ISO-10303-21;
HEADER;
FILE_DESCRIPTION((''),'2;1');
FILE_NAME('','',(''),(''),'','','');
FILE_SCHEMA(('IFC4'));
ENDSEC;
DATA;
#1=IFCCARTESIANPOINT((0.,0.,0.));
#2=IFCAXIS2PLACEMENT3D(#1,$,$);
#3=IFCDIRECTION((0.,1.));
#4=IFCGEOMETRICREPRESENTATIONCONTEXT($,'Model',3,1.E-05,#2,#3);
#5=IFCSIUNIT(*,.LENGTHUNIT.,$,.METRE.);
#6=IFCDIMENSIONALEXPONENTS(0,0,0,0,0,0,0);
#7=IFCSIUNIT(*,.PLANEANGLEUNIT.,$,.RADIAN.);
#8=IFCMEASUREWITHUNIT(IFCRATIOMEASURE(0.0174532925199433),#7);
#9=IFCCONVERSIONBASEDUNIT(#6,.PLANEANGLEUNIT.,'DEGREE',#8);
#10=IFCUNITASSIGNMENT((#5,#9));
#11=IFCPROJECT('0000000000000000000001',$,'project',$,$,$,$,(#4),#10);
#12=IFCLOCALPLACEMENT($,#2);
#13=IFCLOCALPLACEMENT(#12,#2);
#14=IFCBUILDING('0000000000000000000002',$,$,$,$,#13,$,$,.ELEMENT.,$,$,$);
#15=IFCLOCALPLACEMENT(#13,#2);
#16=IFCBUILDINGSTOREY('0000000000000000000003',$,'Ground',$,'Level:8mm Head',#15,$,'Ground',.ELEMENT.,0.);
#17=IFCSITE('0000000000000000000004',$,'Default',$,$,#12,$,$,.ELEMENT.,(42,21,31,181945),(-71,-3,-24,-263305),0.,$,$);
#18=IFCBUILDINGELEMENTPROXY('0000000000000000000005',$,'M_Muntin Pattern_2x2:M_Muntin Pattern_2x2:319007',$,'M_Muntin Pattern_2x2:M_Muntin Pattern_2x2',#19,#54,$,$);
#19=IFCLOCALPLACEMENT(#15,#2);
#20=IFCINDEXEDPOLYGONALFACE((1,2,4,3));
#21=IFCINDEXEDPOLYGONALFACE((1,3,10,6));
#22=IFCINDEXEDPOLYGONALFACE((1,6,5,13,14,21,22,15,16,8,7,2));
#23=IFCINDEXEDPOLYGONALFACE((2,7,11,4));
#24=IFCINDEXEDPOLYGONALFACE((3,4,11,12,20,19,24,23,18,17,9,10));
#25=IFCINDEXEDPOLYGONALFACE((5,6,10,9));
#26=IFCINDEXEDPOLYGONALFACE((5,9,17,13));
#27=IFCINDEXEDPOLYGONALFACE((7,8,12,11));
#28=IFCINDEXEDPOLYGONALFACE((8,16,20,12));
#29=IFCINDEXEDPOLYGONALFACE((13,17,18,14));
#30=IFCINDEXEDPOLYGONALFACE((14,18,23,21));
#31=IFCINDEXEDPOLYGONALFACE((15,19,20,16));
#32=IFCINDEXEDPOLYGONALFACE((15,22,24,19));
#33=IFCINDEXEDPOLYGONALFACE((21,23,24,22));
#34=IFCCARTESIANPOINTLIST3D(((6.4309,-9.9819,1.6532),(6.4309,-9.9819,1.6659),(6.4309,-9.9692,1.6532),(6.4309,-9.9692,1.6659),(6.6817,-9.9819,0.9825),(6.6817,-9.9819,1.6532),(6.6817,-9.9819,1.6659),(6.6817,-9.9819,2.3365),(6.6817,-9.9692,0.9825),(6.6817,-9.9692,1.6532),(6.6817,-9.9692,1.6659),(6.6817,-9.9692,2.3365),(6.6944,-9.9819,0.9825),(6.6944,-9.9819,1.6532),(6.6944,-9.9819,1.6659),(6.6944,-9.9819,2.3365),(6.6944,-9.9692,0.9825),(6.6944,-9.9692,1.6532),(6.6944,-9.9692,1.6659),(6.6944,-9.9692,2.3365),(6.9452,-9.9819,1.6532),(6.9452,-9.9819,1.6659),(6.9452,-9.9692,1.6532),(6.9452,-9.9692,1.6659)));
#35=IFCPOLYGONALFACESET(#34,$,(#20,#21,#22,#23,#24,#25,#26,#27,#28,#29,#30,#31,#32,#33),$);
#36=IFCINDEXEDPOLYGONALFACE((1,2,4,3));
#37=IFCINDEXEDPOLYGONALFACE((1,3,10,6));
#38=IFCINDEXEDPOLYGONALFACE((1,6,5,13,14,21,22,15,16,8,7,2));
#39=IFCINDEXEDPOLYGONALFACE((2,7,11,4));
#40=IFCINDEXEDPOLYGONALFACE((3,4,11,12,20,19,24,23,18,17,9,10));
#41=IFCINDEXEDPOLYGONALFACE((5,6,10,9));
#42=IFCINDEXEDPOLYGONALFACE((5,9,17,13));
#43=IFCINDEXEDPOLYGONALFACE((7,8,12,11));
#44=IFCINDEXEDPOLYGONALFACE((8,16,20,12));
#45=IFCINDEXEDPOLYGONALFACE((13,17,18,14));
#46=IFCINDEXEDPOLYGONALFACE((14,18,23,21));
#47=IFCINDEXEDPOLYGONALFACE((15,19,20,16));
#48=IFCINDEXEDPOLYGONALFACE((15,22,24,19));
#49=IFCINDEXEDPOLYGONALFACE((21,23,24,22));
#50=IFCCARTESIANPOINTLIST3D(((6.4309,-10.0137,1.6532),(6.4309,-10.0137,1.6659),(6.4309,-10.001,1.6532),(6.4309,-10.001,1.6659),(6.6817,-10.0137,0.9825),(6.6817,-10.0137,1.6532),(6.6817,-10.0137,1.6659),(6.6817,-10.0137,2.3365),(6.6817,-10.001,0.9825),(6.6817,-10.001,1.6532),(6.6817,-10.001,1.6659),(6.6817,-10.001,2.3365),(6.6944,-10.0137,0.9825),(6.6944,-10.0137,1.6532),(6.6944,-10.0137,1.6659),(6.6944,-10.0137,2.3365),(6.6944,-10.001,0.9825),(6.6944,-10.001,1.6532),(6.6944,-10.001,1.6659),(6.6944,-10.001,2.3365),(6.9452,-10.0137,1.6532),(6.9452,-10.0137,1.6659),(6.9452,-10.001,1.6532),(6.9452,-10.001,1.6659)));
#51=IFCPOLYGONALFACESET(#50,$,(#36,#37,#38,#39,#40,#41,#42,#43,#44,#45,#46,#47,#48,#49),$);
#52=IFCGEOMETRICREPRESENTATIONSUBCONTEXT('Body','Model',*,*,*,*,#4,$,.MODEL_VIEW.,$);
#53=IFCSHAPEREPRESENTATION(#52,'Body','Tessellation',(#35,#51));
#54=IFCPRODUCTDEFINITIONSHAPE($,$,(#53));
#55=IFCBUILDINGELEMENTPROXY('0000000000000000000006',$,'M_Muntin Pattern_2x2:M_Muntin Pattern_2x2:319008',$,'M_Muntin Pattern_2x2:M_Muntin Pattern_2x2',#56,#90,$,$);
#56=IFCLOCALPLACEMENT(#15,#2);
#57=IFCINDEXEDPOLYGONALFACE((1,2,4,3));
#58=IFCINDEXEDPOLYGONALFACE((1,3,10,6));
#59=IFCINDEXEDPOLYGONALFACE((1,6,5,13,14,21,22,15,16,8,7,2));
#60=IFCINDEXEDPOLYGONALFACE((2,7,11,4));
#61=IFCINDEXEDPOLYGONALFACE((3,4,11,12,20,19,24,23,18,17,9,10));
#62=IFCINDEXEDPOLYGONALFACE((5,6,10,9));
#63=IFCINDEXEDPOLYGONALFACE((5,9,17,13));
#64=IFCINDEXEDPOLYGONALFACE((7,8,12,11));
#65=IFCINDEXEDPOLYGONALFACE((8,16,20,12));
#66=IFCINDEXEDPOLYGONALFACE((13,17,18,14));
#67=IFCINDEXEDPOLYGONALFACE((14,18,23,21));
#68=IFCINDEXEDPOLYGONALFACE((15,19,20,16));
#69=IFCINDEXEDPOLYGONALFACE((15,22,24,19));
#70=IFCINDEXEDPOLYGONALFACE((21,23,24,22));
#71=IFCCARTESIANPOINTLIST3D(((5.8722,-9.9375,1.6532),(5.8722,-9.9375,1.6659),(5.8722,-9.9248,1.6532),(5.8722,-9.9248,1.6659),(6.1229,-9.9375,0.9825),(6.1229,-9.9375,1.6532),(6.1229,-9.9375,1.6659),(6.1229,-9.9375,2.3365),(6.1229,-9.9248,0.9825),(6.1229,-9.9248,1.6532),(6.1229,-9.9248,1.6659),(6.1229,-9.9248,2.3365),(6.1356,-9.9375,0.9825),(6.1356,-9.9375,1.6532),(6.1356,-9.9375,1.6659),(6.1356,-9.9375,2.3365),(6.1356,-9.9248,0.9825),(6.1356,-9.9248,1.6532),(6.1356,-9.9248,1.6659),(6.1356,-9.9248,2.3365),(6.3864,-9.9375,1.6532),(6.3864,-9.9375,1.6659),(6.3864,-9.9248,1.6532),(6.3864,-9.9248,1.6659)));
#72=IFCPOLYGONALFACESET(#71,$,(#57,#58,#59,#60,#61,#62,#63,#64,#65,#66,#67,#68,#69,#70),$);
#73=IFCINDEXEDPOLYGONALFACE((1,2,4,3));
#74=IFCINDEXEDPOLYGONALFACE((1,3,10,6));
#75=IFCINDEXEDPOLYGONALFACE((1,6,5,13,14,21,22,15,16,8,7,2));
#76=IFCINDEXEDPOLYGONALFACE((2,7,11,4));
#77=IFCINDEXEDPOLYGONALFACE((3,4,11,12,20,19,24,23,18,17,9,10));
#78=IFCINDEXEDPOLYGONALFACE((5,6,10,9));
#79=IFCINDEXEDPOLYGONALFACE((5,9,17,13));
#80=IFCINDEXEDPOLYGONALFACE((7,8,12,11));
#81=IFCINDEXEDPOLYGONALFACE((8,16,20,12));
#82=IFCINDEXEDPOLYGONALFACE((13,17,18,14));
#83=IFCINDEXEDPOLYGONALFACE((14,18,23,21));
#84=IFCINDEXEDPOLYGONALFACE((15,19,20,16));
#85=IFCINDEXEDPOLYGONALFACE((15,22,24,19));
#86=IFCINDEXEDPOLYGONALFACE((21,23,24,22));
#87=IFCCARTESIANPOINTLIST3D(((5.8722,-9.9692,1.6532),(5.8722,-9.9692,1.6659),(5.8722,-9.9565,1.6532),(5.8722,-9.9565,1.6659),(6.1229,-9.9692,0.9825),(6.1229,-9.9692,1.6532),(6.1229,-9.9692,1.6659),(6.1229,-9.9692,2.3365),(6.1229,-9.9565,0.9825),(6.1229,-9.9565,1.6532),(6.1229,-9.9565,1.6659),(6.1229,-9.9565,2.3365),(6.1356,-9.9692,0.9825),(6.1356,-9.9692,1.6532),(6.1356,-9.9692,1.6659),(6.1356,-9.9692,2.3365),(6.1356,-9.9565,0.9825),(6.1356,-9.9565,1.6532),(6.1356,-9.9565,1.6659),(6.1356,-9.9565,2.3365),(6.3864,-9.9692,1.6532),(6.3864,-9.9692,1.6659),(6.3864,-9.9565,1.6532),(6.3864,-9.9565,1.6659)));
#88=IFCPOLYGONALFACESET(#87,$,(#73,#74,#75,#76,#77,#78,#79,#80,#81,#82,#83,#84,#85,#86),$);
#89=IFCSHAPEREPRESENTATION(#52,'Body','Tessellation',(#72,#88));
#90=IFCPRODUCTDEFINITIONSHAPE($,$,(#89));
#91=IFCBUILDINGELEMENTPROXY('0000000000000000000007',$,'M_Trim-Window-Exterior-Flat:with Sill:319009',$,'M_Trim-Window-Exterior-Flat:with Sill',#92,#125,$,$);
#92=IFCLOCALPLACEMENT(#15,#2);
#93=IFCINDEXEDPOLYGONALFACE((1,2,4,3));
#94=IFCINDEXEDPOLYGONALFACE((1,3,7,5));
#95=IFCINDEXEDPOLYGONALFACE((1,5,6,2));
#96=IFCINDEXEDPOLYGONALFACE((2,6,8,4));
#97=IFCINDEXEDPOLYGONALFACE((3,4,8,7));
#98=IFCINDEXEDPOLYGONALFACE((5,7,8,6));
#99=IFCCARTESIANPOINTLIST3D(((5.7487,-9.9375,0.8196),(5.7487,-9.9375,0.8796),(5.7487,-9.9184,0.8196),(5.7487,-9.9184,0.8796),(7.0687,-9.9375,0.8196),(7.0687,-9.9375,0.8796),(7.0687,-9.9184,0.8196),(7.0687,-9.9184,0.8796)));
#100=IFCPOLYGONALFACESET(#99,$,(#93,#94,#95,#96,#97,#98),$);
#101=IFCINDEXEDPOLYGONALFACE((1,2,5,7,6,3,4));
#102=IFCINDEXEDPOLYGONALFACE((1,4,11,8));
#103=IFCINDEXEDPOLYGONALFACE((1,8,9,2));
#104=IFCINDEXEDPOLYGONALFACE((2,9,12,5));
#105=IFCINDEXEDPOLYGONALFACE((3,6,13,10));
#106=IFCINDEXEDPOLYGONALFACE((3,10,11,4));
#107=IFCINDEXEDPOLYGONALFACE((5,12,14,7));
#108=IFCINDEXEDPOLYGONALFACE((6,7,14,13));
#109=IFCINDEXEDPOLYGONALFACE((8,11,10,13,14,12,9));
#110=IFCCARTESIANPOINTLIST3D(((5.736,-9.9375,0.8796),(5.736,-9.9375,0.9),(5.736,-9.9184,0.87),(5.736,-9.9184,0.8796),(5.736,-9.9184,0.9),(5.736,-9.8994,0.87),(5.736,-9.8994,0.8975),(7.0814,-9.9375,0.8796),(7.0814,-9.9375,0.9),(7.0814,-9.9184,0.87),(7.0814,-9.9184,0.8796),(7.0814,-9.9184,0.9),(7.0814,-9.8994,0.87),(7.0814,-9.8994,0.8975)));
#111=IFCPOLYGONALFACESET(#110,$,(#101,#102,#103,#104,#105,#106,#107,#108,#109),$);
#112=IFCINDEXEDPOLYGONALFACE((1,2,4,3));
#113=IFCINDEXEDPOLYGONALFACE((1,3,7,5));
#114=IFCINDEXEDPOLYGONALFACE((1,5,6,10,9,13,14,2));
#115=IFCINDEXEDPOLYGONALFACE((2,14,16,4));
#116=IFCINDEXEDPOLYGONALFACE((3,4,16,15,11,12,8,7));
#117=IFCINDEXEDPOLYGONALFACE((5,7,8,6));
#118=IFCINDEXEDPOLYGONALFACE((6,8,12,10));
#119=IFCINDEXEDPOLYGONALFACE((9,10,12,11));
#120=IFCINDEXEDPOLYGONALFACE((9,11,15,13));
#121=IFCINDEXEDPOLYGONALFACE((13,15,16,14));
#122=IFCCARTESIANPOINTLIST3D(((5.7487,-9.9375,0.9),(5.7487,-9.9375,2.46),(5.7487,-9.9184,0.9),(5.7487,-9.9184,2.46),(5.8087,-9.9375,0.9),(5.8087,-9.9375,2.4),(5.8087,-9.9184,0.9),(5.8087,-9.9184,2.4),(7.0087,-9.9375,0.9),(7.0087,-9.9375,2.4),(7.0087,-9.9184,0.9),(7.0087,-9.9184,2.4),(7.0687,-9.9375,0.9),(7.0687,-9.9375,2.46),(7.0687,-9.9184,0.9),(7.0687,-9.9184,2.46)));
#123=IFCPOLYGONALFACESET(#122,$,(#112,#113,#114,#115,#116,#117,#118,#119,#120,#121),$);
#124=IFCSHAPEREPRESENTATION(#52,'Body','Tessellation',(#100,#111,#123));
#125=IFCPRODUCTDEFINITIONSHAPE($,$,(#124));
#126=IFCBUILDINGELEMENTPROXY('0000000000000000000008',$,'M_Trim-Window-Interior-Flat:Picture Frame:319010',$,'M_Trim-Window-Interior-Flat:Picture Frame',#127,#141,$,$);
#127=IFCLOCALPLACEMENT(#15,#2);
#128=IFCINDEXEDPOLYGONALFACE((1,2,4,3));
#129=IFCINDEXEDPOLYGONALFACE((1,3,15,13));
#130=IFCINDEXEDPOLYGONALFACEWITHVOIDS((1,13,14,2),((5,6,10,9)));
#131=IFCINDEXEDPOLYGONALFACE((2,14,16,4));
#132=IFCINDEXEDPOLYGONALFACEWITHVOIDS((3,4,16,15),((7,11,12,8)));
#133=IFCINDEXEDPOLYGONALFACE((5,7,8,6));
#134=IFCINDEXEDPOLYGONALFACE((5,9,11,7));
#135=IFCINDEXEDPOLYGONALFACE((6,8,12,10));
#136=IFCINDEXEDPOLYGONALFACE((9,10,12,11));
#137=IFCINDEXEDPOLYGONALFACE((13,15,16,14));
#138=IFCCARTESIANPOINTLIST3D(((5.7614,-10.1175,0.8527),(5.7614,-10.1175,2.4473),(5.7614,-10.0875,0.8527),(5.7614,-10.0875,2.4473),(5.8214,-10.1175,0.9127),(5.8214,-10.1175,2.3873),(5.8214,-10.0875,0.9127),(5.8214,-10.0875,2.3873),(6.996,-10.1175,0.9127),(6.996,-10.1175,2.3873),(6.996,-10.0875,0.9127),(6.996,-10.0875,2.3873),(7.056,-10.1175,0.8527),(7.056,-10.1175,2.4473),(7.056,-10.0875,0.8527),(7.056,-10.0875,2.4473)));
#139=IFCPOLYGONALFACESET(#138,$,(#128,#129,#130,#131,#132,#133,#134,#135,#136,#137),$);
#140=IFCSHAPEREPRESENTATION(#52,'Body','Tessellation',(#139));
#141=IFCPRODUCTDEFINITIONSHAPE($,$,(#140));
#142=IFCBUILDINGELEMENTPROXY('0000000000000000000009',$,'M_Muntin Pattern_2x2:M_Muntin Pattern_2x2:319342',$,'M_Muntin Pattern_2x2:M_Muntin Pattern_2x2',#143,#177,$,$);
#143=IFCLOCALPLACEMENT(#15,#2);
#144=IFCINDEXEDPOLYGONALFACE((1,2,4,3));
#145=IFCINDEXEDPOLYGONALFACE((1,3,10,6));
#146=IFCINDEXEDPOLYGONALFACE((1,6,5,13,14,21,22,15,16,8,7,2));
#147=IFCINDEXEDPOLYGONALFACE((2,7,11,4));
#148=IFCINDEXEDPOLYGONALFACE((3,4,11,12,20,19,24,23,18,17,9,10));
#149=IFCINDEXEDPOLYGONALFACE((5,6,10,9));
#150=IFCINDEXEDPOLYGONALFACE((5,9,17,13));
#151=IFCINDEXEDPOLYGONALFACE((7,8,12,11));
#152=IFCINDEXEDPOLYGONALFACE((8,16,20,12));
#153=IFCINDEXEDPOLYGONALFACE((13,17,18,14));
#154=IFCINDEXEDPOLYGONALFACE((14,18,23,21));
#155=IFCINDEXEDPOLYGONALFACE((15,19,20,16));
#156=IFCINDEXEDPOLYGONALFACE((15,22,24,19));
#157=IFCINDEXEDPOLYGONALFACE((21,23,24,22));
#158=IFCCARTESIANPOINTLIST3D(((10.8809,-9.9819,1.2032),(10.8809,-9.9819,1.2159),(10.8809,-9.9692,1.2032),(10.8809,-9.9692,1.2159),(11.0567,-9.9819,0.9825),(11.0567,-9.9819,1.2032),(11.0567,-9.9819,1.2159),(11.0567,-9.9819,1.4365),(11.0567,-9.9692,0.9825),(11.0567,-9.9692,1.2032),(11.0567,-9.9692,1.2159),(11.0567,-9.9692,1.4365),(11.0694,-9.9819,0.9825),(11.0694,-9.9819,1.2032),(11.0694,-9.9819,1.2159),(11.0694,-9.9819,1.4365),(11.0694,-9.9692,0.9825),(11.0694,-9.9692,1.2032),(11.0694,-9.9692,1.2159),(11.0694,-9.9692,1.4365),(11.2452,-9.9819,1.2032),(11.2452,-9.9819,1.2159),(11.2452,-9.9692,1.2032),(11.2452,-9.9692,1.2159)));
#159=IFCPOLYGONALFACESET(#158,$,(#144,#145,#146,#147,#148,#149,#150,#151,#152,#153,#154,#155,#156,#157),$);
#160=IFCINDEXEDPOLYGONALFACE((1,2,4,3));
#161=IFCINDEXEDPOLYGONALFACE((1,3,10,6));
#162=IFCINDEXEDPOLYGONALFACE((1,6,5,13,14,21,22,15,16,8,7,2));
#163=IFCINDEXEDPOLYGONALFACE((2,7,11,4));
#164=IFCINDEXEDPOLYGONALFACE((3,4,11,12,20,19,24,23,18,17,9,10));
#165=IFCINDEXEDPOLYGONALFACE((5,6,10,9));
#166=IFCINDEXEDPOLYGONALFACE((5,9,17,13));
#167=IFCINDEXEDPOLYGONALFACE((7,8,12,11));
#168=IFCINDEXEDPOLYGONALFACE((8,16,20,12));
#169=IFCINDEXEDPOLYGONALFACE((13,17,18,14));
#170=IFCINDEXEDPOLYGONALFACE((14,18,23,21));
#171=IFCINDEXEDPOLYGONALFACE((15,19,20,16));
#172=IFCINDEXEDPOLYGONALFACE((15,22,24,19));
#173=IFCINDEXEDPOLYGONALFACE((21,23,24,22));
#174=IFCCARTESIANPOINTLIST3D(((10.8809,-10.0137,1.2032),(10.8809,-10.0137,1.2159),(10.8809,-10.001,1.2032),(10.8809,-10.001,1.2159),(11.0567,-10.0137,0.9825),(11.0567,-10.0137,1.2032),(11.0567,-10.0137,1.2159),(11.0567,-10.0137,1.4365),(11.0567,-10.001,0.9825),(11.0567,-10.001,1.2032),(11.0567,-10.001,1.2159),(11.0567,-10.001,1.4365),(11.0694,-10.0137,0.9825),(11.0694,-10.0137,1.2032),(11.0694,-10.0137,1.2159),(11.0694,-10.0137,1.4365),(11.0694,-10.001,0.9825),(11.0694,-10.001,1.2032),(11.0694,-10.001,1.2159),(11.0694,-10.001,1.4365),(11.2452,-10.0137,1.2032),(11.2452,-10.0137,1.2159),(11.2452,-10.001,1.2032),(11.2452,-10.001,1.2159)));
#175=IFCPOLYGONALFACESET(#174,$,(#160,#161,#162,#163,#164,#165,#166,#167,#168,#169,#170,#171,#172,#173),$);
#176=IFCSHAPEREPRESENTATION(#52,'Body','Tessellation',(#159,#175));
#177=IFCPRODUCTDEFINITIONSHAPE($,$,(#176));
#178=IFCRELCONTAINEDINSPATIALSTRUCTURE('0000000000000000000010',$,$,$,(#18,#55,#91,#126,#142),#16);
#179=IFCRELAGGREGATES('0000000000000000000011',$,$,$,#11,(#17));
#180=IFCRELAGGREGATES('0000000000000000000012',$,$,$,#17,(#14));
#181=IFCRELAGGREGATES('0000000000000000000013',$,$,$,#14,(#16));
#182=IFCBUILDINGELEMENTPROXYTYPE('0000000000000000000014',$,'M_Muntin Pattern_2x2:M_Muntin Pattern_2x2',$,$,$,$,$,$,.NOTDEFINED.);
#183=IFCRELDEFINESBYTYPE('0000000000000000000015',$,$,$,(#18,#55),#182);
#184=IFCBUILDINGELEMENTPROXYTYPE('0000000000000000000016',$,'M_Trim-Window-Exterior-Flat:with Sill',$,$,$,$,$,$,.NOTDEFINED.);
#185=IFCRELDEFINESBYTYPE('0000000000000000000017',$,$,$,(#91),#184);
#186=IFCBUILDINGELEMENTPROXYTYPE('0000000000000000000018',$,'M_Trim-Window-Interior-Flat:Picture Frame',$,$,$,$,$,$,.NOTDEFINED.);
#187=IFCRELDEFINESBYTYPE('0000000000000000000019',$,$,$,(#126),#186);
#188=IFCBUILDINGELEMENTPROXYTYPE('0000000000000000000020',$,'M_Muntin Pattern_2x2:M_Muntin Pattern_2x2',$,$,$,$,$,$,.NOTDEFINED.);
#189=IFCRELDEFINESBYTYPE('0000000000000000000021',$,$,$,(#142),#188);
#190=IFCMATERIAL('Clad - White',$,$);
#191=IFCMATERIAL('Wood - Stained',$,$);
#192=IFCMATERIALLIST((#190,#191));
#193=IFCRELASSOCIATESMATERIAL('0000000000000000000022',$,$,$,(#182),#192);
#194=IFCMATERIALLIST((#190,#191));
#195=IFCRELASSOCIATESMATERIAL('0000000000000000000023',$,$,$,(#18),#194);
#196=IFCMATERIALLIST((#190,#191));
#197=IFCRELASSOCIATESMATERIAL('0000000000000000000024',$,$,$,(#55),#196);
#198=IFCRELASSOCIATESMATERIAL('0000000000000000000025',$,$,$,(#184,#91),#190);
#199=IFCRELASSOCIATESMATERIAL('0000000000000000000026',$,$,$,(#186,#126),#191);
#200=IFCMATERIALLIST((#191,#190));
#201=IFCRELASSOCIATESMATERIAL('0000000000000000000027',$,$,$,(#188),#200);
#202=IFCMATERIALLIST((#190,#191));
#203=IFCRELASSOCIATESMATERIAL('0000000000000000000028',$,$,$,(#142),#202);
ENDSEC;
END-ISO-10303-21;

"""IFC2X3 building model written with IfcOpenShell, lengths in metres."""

from ifc_helpers import new_model, entity, si_unit, converted_unit, direction, frame, frame_2d, origin, place, context, subcontext, project, spatial, polyline, rectangle, outline, extrude, source, transform, mapped, material, material_list, type_object, type_shapes, element, save


model = new_model("IFC2X3")

# Units and contexts
model_context = context("Model", 3, precision=1e-05, world=origin(), true_north=direction((0.0, 1.0)))
body_context = subcontext(model_context, "Body", "Model", "MODEL_VIEW")
ifc_project = project(units=[si_unit("LENGTHUNIT", "METRE"), converted_unit("PLANEANGLEUNIT", "DEGREE", entity("IfcRatioMeasure", 0.0174532925199433), si_unit("PLANEANGLEUNIT", "RADIAN"), dimensions=[0, 0, 0, 0, 0, 0, 0])], contexts=[model_context])

# Site, building, storey
site_placement = place(None, origin())
site = spatial("IfcSite", under=ifc_project, at=site_placement, Name="Default", CompositionType="ELEMENT", RefLatitude=(42, 21, 31, 181945), RefLongitude=(-71, -3, -24, -263305), RefElevation=0.0)
building_placement = place(site_placement, origin())
building = spatial("IfcBuilding", under=site, at=building_placement, CompositionType="ELEMENT")
storey_placement = place(building_placement, origin())
storey = spatial("IfcBuildingStorey", under=building, at=storey_placement, Name="Ground", ObjectType="Level:8mm Head", LongName="Ground", CompositionType="ELEMENT", Elevation=0.0)

# Building element proxies
ifc_material_1 = material(Name="Clad - White")
ifc_material_2 = material(Name="Wood - Stained")
ifc_material_list_1 = material_list([ifc_material_1, ifc_material_2])
ifc_material_list_2 = material_list([ifc_material_1, ifc_material_2])
building_element_proxy_type_1 = type_object("IfcBuildingElementProxyType", Name="M_Muntin Pattern_2x2:M_Muntin Pattern_2x2", PredefinedType="NOTDEFINED", material=ifc_material_list_2)
shared_shape_1 = source(origin(), body_context, "Body", "SweptSolid", [
    extrude(outline(polyline([(0.0064, -0.0064), (0.677, -0.0064), (0.677, 0.0063), (0.0064, 0.0063), (0.0064, 0.2571), (-0.0063, 0.2571), (-0.0063, 0.0063), (-0.677, 0.0063), (-0.677, -0.0064), (-0.0063, -0.0064), (-0.0063, -0.2571), (0.0064, -0.2571), (0.0064, -0.0064)])), frame((0.0, 0.0095, 0.677), z_axis=(0.0, 1.0, 0.0), x_axis=(0.0, 0.0, 1.0)), (0.0, 0.0, 1.0), 0.0127),
    extrude(outline(polyline([(0.0064, -0.0064), (0.677, -0.0064), (0.677, 0.0063), (0.0064, 0.0063), (0.0064, 0.2571), (-0.0063, 0.2571), (-0.0063, 0.0063), (-0.677, 0.0063), (-0.677, -0.0064), (-0.0063, -0.0064), (-0.0063, -0.2571), (0.0064, -0.2571), (0.0064, -0.0064)])), frame((0.0, -0.0222, 0.677), z_axis=(0.0, 1.0, 0.0), x_axis=(0.0, 0.0, 1.0)), (0.0, 0.0, 1.0), 0.0127),
])
type_shapes(building_element_proxy_type_1, [shared_shape_1])
proxy_1_placement = place(storey_placement, frame((6.688, -9.9914, 0.9825)))
element("IfcBuildingElementProxy", 1, at=proxy_1_placement, inside=storey, type_object=building_element_proxy_type_1, material=ifc_material_list_1, Name="M_Muntin Pattern_2x2:M_Muntin Pattern_2x2:319007", ObjectType="M_Muntin Pattern_2x2:M_Muntin Pattern_2x2", context=body_context, shape_type="MappedRepresentation", body=[
    mapped(shared_shape_1, transform((0.0, 0.0, 0.0), scale=1.0)),
])
ifc_material_list_3 = material_list([ifc_material_1, ifc_material_2])
proxy_2_placement = place(storey_placement, frame((6.1293, -9.947, 0.9825)))
element("IfcBuildingElementProxy", 2, at=proxy_2_placement, inside=storey, type_object=building_element_proxy_type_1, material=ifc_material_list_3, Name="M_Muntin Pattern_2x2:M_Muntin Pattern_2x2:319008", ObjectType="M_Muntin Pattern_2x2:M_Muntin Pattern_2x2", context=body_context, shape_type="MappedRepresentation", body=[
    mapped(shared_shape_1, transform((0.0, 0.0, 0.0), scale=1.0)),
])
building_element_proxy_type_2 = type_object("IfcBuildingElementProxyType", Name="M_Trim-Window-Exterior-Flat:with Sill", PredefinedType="NOTDEFINED", material=ifc_material_1)
shared_shape_2 = source(origin(), body_context, "Body", "SweptSolid", [
    extrude(rectangle(XDim=1.32, YDim=0.06, at=frame_2d((0.0, 0.0), x_axis=(1.0, 0.0))), frame((0.0, -1.5504, 0.0), z_axis=(0.0, 0.0, 1.0), x_axis=(-1.0, 0.0, 0.0)), (0.0, 0.0, 1.0), 0.0191),
    extrude(outline(polyline([(-0.019, -0.0152), (0.0, -0.0152), (0.0, -0.0057), (0.019, -0.0057), (0.019, 0.0148), (0.0, 0.0148), (-0.019, 0.0123), (-0.019, -0.0152)])), frame((-0.6727, -1.5148, 0.019), z_axis=(1.0, 0.0, 0.0), x_axis=(0.0, 0.0, -1.0)), (0.0, 0.0, 1.0), 1.3454),
    extrude(outline(polyline([(-0.795, -0.66), (0.765, -0.66), (0.765, -0.6), (-0.735, -0.6), (-0.735, 0.6), (0.765, 0.6), (0.765, 0.66), (-0.795, 0.66), (-0.795, -0.66)])), frame((0.0, -0.735, 0.0), z_axis=(0.0, 0.0, 1.0), x_axis=(0.0, -1.0, 0.0)), (0.0, 0.0, 1.0), 0.0191),
])
type_shapes(building_element_proxy_type_2, [shared_shape_2])
proxy_3_placement = place(storey_placement, frame((6.4087, -9.9375, 2.4), z_axis=(0.0, 1.0, 0.0), x_axis=(-1.0, 0.0, 0.0)))
element("IfcBuildingElementProxy", 3, at=proxy_3_placement, inside=storey, type_object=building_element_proxy_type_2, material=ifc_material_1, Name="M_Trim-Window-Exterior-Flat:with Sill:319009", ObjectType="M_Trim-Window-Exterior-Flat:with Sill", context=body_context, shape_type="MappedRepresentation", body=[
    mapped(shared_shape_2, transform((0.0, 0.0, 0.0), scale=1.0)),
])
building_element_proxy_type_3 = type_object("IfcBuildingElementProxyType", Name="M_Trim-Window-Interior-Flat:Picture Frame", PredefinedType="NOTDEFINED", material=ifc_material_2)
shared_shape_3 = source(origin(), body_context, "Body", "SweptSolid", [
    extrude(outline(polyline([(-0.6473, -0.7973), (0.6473, -0.7973), (0.6473, 0.7973), (-0.6473, 0.7973), (-0.6473, -0.7973)]), holes=[polyline([(-0.5873, -0.7373), (-0.5873, 0.7373), (0.5873, 0.7373), (0.5873, -0.7373), (-0.5873, -0.7373)])]), frame((0.0, -0.75, 0.0), z_axis=(0.0, 0.0, 1.0), x_axis=(-1.0, 0.0, 0.0)), (0.0, 0.0, 1.0), 0.03),
])
type_shapes(building_element_proxy_type_3, [shared_shape_3])
proxy_4_placement = place(storey_placement, frame((6.4087, -10.0875, 2.4), z_axis=(0.0, -1.0, 0.0), x_axis=(1.0, 0.0, 0.0)))
element("IfcBuildingElementProxy", 4, at=proxy_4_placement, inside=storey, type_object=building_element_proxy_type_3, material=ifc_material_2, Name="M_Trim-Window-Interior-Flat:Picture Frame:319010", ObjectType="M_Trim-Window-Interior-Flat:Picture Frame", context=body_context, shape_type="MappedRepresentation", body=[
    mapped(shared_shape_3, transform((0.0, 0.0, 0.0), scale=1.0)),
])
ifc_material_list_4 = material_list([ifc_material_1, ifc_material_2])
ifc_material_list_5 = material_list([ifc_material_2, ifc_material_1])
building_element_proxy_type_4 = type_object("IfcBuildingElementProxyType", Name="M_Muntin Pattern_2x2:M_Muntin Pattern_2x2", PredefinedType="NOTDEFINED", material=ifc_material_list_5)
shared_shape_4 = source(origin(), body_context, "Body", "SweptSolid", [
    extrude(outline(polyline([(0.0064, -0.0064), (0.227, -0.0064), (0.227, 0.0063), (0.0064, 0.0063), (0.0064, 0.1821), (-0.0063, 0.1821), (-0.0063, 0.0063), (-0.227, 0.0063), (-0.227, -0.0064), (-0.0063, -0.0064), (-0.0063, -0.1821), (0.0064, -0.1821), (0.0064, -0.0064)])), frame((0.0, 0.0095, 0.227), z_axis=(0.0, 1.0, 0.0), x_axis=(0.0, 0.0, 1.0)), (0.0, 0.0, 1.0), 0.0127),
    extrude(outline(polyline([(0.0064, -0.0064), (0.227, -0.0064), (0.227, 0.0063), (0.0064, 0.0063), (0.0064, 0.1821), (-0.0063, 0.1821), (-0.0063, 0.0063), (-0.227, 0.0063), (-0.227, -0.0064), (-0.0063, -0.0064), (-0.0063, -0.1821), (0.0064, -0.1821), (0.0064, -0.0064)])), frame((0.0, -0.0222, 0.227), z_axis=(0.0, 1.0, 0.0), x_axis=(0.0, 0.0, 1.0)), (0.0, 0.0, 1.0), 0.0127),
])
type_shapes(building_element_proxy_type_4, [shared_shape_4])
proxy_5_placement = place(storey_placement, frame((11.063, -9.9914, 0.9825)))
element("IfcBuildingElementProxy", 5, at=proxy_5_placement, inside=storey, type_object=building_element_proxy_type_4, material=ifc_material_list_4, Name="M_Muntin Pattern_2x2:M_Muntin Pattern_2x2:319342", ObjectType="M_Muntin Pattern_2x2:M_Muntin Pattern_2x2", context=body_context, shape_type="MappedRepresentation", body=[
    mapped(shared_shape_4, transform((0.0, 0.0, 0.0), scale=1.0)),
])

save(model, "model.ifc")
